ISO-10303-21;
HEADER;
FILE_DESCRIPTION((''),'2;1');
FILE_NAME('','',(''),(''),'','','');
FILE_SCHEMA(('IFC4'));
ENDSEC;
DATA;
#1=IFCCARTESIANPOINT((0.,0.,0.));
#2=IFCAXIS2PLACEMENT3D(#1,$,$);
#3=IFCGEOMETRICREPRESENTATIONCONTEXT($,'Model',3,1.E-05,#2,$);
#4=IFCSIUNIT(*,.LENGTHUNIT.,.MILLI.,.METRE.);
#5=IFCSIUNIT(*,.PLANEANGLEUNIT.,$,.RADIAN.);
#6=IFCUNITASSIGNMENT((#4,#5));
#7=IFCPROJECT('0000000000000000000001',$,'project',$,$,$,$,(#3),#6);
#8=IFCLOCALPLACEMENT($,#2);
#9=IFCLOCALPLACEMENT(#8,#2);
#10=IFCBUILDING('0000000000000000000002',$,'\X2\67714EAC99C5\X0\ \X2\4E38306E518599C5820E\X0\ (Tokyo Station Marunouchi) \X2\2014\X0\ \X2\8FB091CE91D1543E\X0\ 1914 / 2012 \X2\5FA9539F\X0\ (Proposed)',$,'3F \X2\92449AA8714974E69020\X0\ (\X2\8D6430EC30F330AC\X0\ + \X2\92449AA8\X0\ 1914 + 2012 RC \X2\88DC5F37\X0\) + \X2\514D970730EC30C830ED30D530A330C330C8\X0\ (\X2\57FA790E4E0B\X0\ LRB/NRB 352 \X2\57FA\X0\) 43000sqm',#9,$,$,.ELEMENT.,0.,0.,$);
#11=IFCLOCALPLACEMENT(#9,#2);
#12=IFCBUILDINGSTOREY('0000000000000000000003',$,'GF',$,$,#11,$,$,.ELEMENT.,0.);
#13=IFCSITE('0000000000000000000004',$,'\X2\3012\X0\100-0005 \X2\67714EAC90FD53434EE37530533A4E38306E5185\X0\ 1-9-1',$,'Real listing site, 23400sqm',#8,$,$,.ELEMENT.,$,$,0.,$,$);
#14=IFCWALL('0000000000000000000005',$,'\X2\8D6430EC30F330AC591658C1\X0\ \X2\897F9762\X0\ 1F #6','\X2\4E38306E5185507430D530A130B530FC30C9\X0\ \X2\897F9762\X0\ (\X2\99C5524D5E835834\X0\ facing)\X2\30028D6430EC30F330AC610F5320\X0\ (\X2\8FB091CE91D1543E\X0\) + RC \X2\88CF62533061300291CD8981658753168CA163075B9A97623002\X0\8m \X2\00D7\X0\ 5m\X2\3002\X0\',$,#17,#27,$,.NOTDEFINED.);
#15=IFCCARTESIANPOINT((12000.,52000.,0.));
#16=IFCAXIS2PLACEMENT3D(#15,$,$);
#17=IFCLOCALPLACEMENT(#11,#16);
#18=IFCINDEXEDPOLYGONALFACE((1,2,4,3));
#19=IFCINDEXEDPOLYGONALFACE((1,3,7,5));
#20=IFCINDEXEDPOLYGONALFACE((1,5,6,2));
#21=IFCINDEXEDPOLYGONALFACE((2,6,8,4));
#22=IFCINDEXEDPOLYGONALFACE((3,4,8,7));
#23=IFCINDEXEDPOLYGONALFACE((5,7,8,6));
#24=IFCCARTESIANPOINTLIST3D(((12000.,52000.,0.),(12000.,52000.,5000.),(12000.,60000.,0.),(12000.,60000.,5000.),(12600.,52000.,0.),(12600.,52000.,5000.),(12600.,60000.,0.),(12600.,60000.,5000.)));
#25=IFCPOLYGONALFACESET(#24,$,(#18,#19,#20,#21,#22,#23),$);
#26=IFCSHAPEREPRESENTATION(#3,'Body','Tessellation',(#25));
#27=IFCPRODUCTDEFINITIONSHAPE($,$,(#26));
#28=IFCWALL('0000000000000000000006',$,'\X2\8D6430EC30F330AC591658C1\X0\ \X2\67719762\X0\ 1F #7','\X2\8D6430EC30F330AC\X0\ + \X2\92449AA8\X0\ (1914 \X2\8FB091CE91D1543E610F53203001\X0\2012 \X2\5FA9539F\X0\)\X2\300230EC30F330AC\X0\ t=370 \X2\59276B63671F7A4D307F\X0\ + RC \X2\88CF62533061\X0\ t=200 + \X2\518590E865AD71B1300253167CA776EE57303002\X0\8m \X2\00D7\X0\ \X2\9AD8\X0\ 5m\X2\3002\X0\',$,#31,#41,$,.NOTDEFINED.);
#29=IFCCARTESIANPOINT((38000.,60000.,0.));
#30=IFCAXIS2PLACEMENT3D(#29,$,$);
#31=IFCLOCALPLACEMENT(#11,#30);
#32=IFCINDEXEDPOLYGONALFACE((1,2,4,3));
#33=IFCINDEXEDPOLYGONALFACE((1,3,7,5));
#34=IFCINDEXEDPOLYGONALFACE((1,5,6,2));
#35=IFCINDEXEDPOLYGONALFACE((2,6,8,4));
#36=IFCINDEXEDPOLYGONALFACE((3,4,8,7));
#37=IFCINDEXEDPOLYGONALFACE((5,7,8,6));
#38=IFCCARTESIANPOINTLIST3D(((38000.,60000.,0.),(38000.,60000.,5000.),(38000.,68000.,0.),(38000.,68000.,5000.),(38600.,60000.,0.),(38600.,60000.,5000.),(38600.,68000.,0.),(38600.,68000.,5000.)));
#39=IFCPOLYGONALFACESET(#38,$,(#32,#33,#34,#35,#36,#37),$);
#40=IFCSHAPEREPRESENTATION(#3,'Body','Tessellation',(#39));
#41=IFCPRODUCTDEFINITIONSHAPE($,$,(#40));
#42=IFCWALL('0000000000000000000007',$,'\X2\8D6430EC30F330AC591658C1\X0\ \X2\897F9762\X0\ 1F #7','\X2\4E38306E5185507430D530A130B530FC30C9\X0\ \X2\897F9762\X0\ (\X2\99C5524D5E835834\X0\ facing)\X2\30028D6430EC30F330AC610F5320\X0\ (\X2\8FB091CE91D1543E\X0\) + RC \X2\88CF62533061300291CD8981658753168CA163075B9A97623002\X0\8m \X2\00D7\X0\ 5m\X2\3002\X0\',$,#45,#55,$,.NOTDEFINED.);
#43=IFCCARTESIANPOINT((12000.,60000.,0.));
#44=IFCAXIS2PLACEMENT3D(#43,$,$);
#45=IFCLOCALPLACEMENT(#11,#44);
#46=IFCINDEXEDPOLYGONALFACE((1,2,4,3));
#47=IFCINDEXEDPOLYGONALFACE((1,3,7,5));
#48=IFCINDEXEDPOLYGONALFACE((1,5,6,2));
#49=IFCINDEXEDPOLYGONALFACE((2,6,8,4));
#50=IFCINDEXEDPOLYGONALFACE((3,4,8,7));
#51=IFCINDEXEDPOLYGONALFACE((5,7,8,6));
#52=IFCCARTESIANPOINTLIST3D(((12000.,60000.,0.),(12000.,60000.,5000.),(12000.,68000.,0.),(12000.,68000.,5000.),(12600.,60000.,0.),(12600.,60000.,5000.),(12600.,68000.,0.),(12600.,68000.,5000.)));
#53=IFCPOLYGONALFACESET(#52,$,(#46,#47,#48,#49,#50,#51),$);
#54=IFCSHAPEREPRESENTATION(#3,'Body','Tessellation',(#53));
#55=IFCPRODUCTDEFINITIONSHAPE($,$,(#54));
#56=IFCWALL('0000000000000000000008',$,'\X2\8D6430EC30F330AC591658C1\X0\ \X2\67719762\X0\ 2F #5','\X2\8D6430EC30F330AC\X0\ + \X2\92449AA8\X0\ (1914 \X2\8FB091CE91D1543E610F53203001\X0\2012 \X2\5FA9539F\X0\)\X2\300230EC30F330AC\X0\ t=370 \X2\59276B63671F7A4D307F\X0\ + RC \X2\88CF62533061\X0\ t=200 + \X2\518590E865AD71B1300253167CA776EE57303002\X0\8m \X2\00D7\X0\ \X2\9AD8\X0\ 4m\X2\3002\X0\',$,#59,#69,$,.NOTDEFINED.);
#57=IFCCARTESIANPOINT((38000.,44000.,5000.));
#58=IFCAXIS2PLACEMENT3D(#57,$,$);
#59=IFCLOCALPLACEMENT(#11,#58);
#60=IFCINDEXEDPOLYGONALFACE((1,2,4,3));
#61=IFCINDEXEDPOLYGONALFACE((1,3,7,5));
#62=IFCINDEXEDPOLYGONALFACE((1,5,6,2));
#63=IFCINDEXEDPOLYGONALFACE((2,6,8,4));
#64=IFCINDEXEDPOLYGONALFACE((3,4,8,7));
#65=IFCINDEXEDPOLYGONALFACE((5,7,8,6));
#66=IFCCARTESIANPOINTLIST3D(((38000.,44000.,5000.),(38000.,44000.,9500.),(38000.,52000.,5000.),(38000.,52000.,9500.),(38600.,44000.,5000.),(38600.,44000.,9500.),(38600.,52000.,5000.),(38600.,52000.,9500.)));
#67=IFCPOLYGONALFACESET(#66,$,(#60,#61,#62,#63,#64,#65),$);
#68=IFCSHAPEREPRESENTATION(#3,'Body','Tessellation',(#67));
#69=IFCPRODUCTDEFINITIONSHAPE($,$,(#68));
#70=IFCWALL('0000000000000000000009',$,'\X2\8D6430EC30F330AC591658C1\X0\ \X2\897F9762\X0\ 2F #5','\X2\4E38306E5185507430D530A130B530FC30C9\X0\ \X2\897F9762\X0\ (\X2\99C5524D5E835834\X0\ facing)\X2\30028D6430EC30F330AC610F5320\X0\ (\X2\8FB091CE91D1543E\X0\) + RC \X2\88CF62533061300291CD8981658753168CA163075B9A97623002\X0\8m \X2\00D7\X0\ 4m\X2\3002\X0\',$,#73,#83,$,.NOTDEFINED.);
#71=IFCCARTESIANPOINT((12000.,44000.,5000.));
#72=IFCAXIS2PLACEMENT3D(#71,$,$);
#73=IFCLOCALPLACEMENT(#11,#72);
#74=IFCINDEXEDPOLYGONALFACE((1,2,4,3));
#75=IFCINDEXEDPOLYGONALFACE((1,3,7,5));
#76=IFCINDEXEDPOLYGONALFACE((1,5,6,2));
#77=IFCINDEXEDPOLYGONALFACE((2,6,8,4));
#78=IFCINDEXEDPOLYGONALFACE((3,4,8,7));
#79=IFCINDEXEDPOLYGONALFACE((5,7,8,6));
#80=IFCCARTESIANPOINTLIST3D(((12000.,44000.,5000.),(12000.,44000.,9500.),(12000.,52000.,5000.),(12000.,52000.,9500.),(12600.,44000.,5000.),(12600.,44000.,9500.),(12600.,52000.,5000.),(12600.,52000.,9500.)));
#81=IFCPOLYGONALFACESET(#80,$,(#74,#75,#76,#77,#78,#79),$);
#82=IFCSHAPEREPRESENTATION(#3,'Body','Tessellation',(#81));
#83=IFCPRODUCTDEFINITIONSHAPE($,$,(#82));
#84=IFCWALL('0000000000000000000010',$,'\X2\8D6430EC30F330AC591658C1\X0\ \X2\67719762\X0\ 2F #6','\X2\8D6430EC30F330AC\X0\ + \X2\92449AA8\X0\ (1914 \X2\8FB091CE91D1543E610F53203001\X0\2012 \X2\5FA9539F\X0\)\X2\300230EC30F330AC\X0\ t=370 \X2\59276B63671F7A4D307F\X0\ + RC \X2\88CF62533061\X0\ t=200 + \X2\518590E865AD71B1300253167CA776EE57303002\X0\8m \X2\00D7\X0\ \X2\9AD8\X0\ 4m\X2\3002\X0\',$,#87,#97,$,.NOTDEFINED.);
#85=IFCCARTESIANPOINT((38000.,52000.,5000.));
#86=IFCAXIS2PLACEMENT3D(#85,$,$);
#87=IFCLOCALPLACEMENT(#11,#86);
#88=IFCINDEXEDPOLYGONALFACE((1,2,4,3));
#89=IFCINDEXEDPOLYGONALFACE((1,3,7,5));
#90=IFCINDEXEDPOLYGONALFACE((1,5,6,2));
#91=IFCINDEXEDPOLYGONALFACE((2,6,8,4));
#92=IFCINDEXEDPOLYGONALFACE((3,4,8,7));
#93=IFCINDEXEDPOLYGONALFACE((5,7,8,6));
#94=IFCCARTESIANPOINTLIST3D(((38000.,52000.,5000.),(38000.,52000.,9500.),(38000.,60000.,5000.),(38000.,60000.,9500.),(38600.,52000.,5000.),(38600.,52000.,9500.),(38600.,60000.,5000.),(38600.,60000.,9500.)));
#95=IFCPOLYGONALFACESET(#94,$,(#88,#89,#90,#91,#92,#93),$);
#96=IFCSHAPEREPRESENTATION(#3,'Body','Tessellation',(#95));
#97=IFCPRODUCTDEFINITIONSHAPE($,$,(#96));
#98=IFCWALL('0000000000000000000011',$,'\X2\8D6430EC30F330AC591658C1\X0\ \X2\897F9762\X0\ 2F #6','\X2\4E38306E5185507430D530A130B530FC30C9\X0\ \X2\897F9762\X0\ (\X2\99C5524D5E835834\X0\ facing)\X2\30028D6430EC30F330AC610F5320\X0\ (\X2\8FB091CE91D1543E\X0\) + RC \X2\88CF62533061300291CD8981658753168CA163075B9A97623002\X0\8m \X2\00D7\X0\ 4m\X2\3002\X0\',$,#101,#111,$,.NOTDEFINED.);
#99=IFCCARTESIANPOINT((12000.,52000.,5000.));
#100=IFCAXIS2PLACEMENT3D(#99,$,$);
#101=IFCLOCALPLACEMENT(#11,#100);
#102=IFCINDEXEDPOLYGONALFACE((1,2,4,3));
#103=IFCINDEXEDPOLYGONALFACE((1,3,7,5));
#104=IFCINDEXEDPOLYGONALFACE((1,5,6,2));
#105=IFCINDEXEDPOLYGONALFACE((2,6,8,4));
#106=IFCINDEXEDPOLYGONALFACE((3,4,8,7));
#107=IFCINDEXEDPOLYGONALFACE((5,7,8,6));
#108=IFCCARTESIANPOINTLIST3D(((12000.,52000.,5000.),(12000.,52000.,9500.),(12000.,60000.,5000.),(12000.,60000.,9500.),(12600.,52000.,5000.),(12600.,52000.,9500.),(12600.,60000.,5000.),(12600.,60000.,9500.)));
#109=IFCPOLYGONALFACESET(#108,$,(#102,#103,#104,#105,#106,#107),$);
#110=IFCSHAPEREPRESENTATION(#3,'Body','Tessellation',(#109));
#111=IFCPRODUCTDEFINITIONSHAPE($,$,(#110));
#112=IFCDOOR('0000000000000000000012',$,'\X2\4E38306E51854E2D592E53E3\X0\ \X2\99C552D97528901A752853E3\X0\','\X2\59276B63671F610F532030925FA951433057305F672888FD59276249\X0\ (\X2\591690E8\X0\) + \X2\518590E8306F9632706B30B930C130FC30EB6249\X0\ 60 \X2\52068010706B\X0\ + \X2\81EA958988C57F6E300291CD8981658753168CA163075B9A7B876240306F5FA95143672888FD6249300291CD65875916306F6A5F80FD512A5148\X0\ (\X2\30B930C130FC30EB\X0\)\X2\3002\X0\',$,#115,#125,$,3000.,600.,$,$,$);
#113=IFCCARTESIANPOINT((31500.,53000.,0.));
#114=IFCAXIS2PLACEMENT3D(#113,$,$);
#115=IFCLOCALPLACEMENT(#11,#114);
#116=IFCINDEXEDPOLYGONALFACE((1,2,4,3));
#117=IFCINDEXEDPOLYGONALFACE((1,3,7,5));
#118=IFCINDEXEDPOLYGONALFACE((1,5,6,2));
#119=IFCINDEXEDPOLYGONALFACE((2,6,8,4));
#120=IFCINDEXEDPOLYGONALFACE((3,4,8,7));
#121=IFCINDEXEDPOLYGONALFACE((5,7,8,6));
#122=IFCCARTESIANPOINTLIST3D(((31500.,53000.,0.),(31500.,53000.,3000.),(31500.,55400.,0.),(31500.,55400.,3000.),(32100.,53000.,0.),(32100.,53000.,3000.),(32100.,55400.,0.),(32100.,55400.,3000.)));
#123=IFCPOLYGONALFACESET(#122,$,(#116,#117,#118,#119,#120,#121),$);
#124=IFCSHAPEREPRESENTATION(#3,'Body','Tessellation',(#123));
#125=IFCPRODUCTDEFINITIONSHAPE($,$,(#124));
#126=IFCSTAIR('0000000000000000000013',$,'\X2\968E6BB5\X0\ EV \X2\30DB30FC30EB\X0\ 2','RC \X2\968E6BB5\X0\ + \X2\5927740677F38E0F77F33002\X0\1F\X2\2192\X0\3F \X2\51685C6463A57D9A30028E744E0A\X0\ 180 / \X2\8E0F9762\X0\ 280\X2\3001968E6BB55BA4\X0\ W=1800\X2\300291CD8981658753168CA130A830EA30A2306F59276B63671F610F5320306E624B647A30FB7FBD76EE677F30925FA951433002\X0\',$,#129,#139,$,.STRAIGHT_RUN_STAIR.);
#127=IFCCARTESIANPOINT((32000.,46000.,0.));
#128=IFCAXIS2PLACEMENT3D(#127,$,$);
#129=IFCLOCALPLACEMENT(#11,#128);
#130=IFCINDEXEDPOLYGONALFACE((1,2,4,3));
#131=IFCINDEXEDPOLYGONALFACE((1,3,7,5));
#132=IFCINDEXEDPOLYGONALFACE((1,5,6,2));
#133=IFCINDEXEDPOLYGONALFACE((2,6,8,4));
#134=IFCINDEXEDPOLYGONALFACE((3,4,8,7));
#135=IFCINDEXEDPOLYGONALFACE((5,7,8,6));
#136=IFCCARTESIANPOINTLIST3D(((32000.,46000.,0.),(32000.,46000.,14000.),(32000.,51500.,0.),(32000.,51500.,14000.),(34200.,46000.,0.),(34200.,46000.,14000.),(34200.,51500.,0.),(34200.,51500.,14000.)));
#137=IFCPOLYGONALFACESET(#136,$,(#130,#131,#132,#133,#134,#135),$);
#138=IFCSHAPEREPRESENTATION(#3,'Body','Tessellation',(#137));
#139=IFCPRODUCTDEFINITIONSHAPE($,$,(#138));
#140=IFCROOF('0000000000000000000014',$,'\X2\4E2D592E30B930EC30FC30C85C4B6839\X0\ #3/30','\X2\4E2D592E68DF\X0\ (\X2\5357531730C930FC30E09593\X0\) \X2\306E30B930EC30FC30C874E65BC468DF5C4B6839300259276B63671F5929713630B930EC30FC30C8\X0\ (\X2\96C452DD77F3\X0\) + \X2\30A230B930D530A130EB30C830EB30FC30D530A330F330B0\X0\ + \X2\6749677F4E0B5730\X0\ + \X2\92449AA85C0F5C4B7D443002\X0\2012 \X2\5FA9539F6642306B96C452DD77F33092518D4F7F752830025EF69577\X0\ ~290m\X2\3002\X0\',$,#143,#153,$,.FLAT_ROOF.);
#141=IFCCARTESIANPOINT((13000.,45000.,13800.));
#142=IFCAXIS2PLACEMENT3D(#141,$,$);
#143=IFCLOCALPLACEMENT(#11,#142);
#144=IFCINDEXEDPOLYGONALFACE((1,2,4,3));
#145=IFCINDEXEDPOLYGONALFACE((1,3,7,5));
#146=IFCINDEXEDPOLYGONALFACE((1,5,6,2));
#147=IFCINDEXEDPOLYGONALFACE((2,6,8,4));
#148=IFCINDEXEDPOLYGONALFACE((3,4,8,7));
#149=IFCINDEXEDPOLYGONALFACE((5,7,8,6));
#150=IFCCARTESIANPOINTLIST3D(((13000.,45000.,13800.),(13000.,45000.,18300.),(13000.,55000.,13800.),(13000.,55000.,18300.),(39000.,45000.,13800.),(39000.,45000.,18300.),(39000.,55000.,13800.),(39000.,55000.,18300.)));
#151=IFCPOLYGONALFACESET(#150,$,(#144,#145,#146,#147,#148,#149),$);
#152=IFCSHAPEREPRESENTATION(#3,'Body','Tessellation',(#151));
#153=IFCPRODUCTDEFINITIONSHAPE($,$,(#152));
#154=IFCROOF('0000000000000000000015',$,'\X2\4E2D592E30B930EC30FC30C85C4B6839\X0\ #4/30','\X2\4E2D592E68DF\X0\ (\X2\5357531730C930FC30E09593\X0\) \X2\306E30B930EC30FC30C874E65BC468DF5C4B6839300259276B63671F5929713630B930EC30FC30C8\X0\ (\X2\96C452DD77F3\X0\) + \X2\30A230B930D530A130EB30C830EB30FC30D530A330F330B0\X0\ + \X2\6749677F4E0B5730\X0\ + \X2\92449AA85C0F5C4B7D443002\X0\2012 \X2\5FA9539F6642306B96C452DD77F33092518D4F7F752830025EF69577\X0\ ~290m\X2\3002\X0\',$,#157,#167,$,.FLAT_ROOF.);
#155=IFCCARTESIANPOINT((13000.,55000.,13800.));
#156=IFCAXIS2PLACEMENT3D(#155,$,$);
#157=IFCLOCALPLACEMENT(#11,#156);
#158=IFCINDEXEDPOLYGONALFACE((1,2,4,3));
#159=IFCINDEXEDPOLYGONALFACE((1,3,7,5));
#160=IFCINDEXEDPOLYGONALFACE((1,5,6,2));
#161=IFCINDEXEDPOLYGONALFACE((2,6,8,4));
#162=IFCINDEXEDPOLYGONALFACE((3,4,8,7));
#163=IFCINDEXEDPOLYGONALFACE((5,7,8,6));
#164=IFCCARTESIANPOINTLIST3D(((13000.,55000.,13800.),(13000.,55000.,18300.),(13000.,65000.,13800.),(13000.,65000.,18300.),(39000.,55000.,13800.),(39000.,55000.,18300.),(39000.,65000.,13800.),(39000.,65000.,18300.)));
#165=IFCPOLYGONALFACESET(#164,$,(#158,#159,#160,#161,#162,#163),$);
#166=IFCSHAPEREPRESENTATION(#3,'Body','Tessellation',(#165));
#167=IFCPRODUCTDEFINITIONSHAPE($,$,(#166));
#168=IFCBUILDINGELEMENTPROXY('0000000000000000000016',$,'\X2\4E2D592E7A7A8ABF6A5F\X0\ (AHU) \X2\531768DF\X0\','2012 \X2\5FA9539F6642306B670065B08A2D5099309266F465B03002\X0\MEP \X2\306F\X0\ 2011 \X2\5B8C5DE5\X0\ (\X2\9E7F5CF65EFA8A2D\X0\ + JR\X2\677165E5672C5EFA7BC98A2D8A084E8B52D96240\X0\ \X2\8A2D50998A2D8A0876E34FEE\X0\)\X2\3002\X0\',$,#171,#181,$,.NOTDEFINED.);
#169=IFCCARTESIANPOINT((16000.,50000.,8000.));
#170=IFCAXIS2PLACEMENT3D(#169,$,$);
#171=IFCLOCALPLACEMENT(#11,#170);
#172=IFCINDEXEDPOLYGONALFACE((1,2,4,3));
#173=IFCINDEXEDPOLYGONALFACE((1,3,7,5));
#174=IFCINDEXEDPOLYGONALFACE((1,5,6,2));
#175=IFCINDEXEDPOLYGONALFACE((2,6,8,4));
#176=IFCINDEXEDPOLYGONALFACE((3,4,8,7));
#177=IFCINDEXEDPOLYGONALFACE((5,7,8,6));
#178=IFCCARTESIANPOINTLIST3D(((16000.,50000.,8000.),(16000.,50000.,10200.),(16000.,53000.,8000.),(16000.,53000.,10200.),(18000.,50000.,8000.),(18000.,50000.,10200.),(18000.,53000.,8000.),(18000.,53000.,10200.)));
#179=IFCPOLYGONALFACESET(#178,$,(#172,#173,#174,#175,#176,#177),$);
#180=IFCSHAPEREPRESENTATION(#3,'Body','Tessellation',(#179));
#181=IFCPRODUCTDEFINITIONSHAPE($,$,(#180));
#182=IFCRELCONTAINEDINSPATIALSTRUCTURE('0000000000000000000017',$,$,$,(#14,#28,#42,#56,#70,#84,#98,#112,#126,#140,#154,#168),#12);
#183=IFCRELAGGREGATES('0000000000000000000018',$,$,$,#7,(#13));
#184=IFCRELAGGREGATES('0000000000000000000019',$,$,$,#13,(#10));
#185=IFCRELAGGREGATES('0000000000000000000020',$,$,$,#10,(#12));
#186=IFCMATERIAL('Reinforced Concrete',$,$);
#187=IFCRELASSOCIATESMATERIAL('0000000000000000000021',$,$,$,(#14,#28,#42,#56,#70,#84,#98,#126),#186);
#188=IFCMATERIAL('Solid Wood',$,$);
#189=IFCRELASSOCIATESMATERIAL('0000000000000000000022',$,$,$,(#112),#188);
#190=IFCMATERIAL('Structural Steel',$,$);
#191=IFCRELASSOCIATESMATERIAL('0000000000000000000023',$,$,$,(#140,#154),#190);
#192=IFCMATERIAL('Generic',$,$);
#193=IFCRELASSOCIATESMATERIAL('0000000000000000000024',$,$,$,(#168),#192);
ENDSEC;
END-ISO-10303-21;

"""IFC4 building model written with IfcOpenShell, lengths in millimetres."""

from ifc_helpers import new_model, si_unit, frame, frame_2d, origin, place, context, project, spatial, rectangle, extrude, material, element, save


model = new_model("IFC4")

# Units and contexts
model_context = context("Model", 3, precision=1e-05, world=origin())
ifc_project = project(units=[si_unit("LENGTHUNIT", "METRE", prefix="MILLI"), si_unit("PLANEANGLEUNIT", "RADIAN")], contexts=[model_context])

# Site, building, storey
site_placement = place(None, origin())
site = spatial("IfcSite", under=ifc_project, at=site_placement, Name="〒100-0005 東京都千代田区丸の内 1-9-1", ObjectType="Real listing site, 23400sqm", CompositionType="ELEMENT", RefElevation=0.0)
building_placement = place(site_placement, origin())
building = spatial("IfcBuilding", under=site, at=building_placement, Name="東京駅 丸の内駅舎 (Tokyo Station Marunouchi) — 辰野金吾 1914 / 2012 復原 (Proposed)", ObjectType="3F 鉄骨煉瓦造 (赤レンガ + 鉄骨 1914 + 2012 RC 補強) + 免震レトロフィット (基礎下 LRB/NRB 352 基) 43000sqm", CompositionType="ELEMENT", ElevationOfRefHeight=0.0, ElevationOfTerrain=0.0)
storey_placement = place(building_placement, origin())
storey = spatial("IfcBuildingStorey", under=building, at=storey_placement, Name="GF", CompositionType="ELEMENT", Elevation=0.0)

# Shared definitions
ifc_material_1 = material(Name="Structural Steel")

# Shared definitions
ifc_material_2 = material(Name="Reinforced Concrete")
ifc_material_3 = material(Name="Generic")

# Shared definitions
ifc_material_4 = material(Name="Solid Wood")

# Walls
wall_1_placement = place(storey_placement, frame((12000.0, 52000.0, 0.0)))
element("IfcWall", 1, at=wall_1_placement, inside=storey, material=ifc_material_2, Name="赤レンガ外壁 西面 1F #6", Description="丸の内側ファサード 西面 (駅前広場 facing)。赤レンガ意匠 (辰野金吾) + RC 裏打ち。重要文化財指定面。8m × 5m。", PredefinedType="NOTDEFINED", context=model_context, shape_type="SweptSolid", body=[
    extrude(rectangle(XDim=600.0, YDim=8000.0, at=frame_2d((300.0, 4000.0))), frame((12000.0, 52000.0, 0.0)), (0.0, 0.0, 1.0), 5000.0),
])
wall_2_placement = place(storey_placement, frame((38000.0, 60000.0, 0.0)))
element("IfcWall", 2, at=wall_2_placement, inside=storey, material=ifc_material_2, Name="赤レンガ外壁 東面 1F #7", Description="赤レンガ + 鉄骨 (1914 辰野金吾意匠、2012 復原)。レンガ t=370 大正期積み + RC 裏打ち t=200 + 内部断熱。化粧目地。8m × 高 5m。", PredefinedType="NOTDEFINED", context=model_context, shape_type="SweptSolid", body=[
    extrude(rectangle(XDim=600.0, YDim=8000.0, at=frame_2d((300.0, 4000.0))), frame((38000.0, 60000.0, 0.0)), (0.0, 0.0, 1.0), 5000.0),
])
wall_3_placement = place(storey_placement, frame((12000.0, 60000.0, 0.0)))
element("IfcWall", 3, at=wall_3_placement, inside=storey, material=ifc_material_2, Name="赤レンガ外壁 西面 1F #7", Description="丸の内側ファサード 西面 (駅前広場 facing)。赤レンガ意匠 (辰野金吾) + RC 裏打ち。重要文化財指定面。8m × 5m。", PredefinedType="NOTDEFINED", context=model_context, shape_type="SweptSolid", body=[
    extrude(rectangle(XDim=600.0, YDim=8000.0, at=frame_2d((300.0, 4000.0))), frame((12000.0, 60000.0, 0.0)), (0.0, 0.0, 1.0), 5000.0),
])
wall_4_placement = place(storey_placement, frame((38000.0, 44000.0, 5000.0)))
element("IfcWall", 4, at=wall_4_placement, inside=storey, material=ifc_material_2, Name="赤レンガ外壁 東面 2F #5", Description="赤レンガ + 鉄骨 (1914 辰野金吾意匠、2012 復原)。レンガ t=370 大正期積み + RC 裏打ち t=200 + 内部断熱。化粧目地。8m × 高 4m。", PredefinedType="NOTDEFINED", context=model_context, shape_type="SweptSolid", body=[
    extrude(rectangle(XDim=600.0, YDim=8000.0, at=frame_2d((300.0, 4000.0))), frame((38000.0, 44000.0, 5000.0)), (0.0, 0.0, 1.0), 4500.0),
])
wall_5_placement = place(storey_placement, frame((12000.0, 44000.0, 5000.0)))
element("IfcWall", 5, at=wall_5_placement, inside=storey, material=ifc_material_2, Name="赤レンガ外壁 西面 2F #5", Description="丸の内側ファサード 西面 (駅前広場 facing)。赤レンガ意匠 (辰野金吾) + RC 裏打ち。重要文化財指定面。8m × 4m。", PredefinedType="NOTDEFINED", context=model_context, shape_type="SweptSolid", body=[
    extrude(rectangle(XDim=600.0, YDim=8000.0, at=frame_2d((300.0, 4000.0))), frame((12000.0, 44000.0, 5000.0)), (0.0, 0.0, 1.0), 4500.0),
])
wall_6_placement = place(storey_placement, frame((38000.0, 52000.0, 5000.0)))
element("IfcWall", 6, at=wall_6_placement, inside=storey, material=ifc_material_2, Name="赤レンガ外壁 東面 2F #6", Description="赤レンガ + 鉄骨 (1914 辰野金吾意匠、2012 復原)。レンガ t=370 大正期積み + RC 裏打ち t=200 + 内部断熱。化粧目地。8m × 高 4m。", PredefinedType="NOTDEFINED", context=model_context, shape_type="SweptSolid", body=[
    extrude(rectangle(XDim=600.0, YDim=8000.0, at=frame_2d((300.0, 4000.0))), frame((38000.0, 52000.0, 5000.0)), (0.0, 0.0, 1.0), 4500.0),
])
wall_7_placement = place(storey_placement, frame((12000.0, 52000.0, 5000.0)))
element("IfcWall", 7, at=wall_7_placement, inside=storey, material=ifc_material_2, Name="赤レンガ外壁 西面 2F #6", Description="丸の内側ファサード 西面 (駅前広場 facing)。赤レンガ意匠 (辰野金吾) + RC 裏打ち。重要文化財指定面。8m × 4m。", PredefinedType="NOTDEFINED", context=model_context, shape_type="SweptSolid", body=[
    extrude(rectangle(XDim=600.0, YDim=8000.0, at=frame_2d((300.0, 4000.0))), frame((12000.0, 52000.0, 5000.0)), (0.0, 0.0, 1.0), 4500.0),
])

# Door
door_placement = place(storey_placement, frame((31500.0, 53000.0, 0.0)))
element("IfcDoor", 8, at=door_placement, inside=storey, material=ifc_material_4, Name="丸の内中央口 駅務用通用口", Description="大正期意匠を復元した木製大扉 (外部) + 内部は防火スチール扉 60 分耐火 + 自閉装置。重要文化財指定箇所は復元木製扉。重文外は機能優先 (スチール)。", OverallHeight=3000.0, OverallWidth=600.0, context=model_context, shape_type="SweptSolid", body=[
    extrude(rectangle(XDim=600.0, YDim=2400.0, at=frame_2d((300.0, 1200.0))), frame((31500.0, 53000.0, 0.0)), (0.0, 0.0, 1.0), 3000.0),
])

# Stair
stair_placement = place(storey_placement, frame((32000.0, 46000.0, 0.0)))
element("IfcStair", 9, at=stair_placement, inside=storey, material=ifc_material_2, Name="階段 EV ホール 2", Description="RC 階段 + 大理石踏石。1F→3F 全層接続。蹴上 180 / 踏面 280、階段室 W=1800。重要文化財エリアは大正期意匠の手摺・羽目板を復元。", PredefinedType="STRAIGHT_RUN_STAIR", context=model_context, shape_type="SweptSolid", body=[
    extrude(rectangle(XDim=2200.0, YDim=5500.0, at=frame_2d((1100.0, 2750.0))), frame((32000.0, 46000.0, 0.0)), (0.0, 0.0, 1.0), 14000.0),
])

# Roofs
roof_1_placement = place(storey_placement, frame((13000.0, 45000.0, 13800.0)))
element("IfcRoof", 10, at=roof_1_placement, inside=storey, material=ifc_material_1, Name="中央スレート屋根 #3/30", Description="中央棟 (南北ドーム間) のスレート瓦寄棟屋根。大正期天然スレート (雄勝石) + アスファルトルーフィング + 杉板下地 + 鉄骨小屋組。2012 復原時に雄勝石を再使用。延長 ~290m。", PredefinedType="FLAT_ROOF", context=model_context, shape_type="SweptSolid", body=[
    extrude(rectangle(XDim=26000.0, YDim=10000.0, at=frame_2d((13000.0, 5000.0))), frame((13000.0, 45000.0, 13800.0)), (0.0, 0.0, 1.0), 4500.0),
])
roof_2_placement = place(storey_placement, frame((13000.0, 55000.0, 13800.0)))
element("IfcRoof", 11, at=roof_2_placement, inside=storey, material=ifc_material_1, Name="中央スレート屋根 #4/30", Description="中央棟 (南北ドーム間) のスレート瓦寄棟屋根。大正期天然スレート (雄勝石) + アスファルトルーフィング + 杉板下地 + 鉄骨小屋組。2012 復原時に雄勝石を再使用。延長 ~290m。", PredefinedType="FLAT_ROOF", context=model_context, shape_type="SweptSolid", body=[
    extrude(rectangle(XDim=26000.0, YDim=10000.0, at=frame_2d((13000.0, 5000.0))), frame((13000.0, 55000.0, 13800.0)), (0.0, 0.0, 1.0), 4500.0),
])

# Building element proxy
proxy_placement = place(storey_placement, frame((16000.0, 50000.0, 8000.0)))
element("IfcBuildingElementProxy", 12, at=proxy_placement, inside=storey, material=ifc_material_3, Name="中央空調機 (AHU) 北棟", Description="2012 復原時に最新設備を更新。MEP は 2011 完工 (鹿島建設 + JR東日本建築設計事務所 設備設計監修)。", PredefinedType="NOTDEFINED", context=model_context, shape_type="SweptSolid", body=[
    extrude(rectangle(XDim=2000.0, YDim=3000.0, at=frame_2d((1000.0, 1500.0))), frame((16000.0, 50000.0, 8000.0)), (0.0, 0.0, 1.0), 2200.0),
])

save(model, "model.ifc")
